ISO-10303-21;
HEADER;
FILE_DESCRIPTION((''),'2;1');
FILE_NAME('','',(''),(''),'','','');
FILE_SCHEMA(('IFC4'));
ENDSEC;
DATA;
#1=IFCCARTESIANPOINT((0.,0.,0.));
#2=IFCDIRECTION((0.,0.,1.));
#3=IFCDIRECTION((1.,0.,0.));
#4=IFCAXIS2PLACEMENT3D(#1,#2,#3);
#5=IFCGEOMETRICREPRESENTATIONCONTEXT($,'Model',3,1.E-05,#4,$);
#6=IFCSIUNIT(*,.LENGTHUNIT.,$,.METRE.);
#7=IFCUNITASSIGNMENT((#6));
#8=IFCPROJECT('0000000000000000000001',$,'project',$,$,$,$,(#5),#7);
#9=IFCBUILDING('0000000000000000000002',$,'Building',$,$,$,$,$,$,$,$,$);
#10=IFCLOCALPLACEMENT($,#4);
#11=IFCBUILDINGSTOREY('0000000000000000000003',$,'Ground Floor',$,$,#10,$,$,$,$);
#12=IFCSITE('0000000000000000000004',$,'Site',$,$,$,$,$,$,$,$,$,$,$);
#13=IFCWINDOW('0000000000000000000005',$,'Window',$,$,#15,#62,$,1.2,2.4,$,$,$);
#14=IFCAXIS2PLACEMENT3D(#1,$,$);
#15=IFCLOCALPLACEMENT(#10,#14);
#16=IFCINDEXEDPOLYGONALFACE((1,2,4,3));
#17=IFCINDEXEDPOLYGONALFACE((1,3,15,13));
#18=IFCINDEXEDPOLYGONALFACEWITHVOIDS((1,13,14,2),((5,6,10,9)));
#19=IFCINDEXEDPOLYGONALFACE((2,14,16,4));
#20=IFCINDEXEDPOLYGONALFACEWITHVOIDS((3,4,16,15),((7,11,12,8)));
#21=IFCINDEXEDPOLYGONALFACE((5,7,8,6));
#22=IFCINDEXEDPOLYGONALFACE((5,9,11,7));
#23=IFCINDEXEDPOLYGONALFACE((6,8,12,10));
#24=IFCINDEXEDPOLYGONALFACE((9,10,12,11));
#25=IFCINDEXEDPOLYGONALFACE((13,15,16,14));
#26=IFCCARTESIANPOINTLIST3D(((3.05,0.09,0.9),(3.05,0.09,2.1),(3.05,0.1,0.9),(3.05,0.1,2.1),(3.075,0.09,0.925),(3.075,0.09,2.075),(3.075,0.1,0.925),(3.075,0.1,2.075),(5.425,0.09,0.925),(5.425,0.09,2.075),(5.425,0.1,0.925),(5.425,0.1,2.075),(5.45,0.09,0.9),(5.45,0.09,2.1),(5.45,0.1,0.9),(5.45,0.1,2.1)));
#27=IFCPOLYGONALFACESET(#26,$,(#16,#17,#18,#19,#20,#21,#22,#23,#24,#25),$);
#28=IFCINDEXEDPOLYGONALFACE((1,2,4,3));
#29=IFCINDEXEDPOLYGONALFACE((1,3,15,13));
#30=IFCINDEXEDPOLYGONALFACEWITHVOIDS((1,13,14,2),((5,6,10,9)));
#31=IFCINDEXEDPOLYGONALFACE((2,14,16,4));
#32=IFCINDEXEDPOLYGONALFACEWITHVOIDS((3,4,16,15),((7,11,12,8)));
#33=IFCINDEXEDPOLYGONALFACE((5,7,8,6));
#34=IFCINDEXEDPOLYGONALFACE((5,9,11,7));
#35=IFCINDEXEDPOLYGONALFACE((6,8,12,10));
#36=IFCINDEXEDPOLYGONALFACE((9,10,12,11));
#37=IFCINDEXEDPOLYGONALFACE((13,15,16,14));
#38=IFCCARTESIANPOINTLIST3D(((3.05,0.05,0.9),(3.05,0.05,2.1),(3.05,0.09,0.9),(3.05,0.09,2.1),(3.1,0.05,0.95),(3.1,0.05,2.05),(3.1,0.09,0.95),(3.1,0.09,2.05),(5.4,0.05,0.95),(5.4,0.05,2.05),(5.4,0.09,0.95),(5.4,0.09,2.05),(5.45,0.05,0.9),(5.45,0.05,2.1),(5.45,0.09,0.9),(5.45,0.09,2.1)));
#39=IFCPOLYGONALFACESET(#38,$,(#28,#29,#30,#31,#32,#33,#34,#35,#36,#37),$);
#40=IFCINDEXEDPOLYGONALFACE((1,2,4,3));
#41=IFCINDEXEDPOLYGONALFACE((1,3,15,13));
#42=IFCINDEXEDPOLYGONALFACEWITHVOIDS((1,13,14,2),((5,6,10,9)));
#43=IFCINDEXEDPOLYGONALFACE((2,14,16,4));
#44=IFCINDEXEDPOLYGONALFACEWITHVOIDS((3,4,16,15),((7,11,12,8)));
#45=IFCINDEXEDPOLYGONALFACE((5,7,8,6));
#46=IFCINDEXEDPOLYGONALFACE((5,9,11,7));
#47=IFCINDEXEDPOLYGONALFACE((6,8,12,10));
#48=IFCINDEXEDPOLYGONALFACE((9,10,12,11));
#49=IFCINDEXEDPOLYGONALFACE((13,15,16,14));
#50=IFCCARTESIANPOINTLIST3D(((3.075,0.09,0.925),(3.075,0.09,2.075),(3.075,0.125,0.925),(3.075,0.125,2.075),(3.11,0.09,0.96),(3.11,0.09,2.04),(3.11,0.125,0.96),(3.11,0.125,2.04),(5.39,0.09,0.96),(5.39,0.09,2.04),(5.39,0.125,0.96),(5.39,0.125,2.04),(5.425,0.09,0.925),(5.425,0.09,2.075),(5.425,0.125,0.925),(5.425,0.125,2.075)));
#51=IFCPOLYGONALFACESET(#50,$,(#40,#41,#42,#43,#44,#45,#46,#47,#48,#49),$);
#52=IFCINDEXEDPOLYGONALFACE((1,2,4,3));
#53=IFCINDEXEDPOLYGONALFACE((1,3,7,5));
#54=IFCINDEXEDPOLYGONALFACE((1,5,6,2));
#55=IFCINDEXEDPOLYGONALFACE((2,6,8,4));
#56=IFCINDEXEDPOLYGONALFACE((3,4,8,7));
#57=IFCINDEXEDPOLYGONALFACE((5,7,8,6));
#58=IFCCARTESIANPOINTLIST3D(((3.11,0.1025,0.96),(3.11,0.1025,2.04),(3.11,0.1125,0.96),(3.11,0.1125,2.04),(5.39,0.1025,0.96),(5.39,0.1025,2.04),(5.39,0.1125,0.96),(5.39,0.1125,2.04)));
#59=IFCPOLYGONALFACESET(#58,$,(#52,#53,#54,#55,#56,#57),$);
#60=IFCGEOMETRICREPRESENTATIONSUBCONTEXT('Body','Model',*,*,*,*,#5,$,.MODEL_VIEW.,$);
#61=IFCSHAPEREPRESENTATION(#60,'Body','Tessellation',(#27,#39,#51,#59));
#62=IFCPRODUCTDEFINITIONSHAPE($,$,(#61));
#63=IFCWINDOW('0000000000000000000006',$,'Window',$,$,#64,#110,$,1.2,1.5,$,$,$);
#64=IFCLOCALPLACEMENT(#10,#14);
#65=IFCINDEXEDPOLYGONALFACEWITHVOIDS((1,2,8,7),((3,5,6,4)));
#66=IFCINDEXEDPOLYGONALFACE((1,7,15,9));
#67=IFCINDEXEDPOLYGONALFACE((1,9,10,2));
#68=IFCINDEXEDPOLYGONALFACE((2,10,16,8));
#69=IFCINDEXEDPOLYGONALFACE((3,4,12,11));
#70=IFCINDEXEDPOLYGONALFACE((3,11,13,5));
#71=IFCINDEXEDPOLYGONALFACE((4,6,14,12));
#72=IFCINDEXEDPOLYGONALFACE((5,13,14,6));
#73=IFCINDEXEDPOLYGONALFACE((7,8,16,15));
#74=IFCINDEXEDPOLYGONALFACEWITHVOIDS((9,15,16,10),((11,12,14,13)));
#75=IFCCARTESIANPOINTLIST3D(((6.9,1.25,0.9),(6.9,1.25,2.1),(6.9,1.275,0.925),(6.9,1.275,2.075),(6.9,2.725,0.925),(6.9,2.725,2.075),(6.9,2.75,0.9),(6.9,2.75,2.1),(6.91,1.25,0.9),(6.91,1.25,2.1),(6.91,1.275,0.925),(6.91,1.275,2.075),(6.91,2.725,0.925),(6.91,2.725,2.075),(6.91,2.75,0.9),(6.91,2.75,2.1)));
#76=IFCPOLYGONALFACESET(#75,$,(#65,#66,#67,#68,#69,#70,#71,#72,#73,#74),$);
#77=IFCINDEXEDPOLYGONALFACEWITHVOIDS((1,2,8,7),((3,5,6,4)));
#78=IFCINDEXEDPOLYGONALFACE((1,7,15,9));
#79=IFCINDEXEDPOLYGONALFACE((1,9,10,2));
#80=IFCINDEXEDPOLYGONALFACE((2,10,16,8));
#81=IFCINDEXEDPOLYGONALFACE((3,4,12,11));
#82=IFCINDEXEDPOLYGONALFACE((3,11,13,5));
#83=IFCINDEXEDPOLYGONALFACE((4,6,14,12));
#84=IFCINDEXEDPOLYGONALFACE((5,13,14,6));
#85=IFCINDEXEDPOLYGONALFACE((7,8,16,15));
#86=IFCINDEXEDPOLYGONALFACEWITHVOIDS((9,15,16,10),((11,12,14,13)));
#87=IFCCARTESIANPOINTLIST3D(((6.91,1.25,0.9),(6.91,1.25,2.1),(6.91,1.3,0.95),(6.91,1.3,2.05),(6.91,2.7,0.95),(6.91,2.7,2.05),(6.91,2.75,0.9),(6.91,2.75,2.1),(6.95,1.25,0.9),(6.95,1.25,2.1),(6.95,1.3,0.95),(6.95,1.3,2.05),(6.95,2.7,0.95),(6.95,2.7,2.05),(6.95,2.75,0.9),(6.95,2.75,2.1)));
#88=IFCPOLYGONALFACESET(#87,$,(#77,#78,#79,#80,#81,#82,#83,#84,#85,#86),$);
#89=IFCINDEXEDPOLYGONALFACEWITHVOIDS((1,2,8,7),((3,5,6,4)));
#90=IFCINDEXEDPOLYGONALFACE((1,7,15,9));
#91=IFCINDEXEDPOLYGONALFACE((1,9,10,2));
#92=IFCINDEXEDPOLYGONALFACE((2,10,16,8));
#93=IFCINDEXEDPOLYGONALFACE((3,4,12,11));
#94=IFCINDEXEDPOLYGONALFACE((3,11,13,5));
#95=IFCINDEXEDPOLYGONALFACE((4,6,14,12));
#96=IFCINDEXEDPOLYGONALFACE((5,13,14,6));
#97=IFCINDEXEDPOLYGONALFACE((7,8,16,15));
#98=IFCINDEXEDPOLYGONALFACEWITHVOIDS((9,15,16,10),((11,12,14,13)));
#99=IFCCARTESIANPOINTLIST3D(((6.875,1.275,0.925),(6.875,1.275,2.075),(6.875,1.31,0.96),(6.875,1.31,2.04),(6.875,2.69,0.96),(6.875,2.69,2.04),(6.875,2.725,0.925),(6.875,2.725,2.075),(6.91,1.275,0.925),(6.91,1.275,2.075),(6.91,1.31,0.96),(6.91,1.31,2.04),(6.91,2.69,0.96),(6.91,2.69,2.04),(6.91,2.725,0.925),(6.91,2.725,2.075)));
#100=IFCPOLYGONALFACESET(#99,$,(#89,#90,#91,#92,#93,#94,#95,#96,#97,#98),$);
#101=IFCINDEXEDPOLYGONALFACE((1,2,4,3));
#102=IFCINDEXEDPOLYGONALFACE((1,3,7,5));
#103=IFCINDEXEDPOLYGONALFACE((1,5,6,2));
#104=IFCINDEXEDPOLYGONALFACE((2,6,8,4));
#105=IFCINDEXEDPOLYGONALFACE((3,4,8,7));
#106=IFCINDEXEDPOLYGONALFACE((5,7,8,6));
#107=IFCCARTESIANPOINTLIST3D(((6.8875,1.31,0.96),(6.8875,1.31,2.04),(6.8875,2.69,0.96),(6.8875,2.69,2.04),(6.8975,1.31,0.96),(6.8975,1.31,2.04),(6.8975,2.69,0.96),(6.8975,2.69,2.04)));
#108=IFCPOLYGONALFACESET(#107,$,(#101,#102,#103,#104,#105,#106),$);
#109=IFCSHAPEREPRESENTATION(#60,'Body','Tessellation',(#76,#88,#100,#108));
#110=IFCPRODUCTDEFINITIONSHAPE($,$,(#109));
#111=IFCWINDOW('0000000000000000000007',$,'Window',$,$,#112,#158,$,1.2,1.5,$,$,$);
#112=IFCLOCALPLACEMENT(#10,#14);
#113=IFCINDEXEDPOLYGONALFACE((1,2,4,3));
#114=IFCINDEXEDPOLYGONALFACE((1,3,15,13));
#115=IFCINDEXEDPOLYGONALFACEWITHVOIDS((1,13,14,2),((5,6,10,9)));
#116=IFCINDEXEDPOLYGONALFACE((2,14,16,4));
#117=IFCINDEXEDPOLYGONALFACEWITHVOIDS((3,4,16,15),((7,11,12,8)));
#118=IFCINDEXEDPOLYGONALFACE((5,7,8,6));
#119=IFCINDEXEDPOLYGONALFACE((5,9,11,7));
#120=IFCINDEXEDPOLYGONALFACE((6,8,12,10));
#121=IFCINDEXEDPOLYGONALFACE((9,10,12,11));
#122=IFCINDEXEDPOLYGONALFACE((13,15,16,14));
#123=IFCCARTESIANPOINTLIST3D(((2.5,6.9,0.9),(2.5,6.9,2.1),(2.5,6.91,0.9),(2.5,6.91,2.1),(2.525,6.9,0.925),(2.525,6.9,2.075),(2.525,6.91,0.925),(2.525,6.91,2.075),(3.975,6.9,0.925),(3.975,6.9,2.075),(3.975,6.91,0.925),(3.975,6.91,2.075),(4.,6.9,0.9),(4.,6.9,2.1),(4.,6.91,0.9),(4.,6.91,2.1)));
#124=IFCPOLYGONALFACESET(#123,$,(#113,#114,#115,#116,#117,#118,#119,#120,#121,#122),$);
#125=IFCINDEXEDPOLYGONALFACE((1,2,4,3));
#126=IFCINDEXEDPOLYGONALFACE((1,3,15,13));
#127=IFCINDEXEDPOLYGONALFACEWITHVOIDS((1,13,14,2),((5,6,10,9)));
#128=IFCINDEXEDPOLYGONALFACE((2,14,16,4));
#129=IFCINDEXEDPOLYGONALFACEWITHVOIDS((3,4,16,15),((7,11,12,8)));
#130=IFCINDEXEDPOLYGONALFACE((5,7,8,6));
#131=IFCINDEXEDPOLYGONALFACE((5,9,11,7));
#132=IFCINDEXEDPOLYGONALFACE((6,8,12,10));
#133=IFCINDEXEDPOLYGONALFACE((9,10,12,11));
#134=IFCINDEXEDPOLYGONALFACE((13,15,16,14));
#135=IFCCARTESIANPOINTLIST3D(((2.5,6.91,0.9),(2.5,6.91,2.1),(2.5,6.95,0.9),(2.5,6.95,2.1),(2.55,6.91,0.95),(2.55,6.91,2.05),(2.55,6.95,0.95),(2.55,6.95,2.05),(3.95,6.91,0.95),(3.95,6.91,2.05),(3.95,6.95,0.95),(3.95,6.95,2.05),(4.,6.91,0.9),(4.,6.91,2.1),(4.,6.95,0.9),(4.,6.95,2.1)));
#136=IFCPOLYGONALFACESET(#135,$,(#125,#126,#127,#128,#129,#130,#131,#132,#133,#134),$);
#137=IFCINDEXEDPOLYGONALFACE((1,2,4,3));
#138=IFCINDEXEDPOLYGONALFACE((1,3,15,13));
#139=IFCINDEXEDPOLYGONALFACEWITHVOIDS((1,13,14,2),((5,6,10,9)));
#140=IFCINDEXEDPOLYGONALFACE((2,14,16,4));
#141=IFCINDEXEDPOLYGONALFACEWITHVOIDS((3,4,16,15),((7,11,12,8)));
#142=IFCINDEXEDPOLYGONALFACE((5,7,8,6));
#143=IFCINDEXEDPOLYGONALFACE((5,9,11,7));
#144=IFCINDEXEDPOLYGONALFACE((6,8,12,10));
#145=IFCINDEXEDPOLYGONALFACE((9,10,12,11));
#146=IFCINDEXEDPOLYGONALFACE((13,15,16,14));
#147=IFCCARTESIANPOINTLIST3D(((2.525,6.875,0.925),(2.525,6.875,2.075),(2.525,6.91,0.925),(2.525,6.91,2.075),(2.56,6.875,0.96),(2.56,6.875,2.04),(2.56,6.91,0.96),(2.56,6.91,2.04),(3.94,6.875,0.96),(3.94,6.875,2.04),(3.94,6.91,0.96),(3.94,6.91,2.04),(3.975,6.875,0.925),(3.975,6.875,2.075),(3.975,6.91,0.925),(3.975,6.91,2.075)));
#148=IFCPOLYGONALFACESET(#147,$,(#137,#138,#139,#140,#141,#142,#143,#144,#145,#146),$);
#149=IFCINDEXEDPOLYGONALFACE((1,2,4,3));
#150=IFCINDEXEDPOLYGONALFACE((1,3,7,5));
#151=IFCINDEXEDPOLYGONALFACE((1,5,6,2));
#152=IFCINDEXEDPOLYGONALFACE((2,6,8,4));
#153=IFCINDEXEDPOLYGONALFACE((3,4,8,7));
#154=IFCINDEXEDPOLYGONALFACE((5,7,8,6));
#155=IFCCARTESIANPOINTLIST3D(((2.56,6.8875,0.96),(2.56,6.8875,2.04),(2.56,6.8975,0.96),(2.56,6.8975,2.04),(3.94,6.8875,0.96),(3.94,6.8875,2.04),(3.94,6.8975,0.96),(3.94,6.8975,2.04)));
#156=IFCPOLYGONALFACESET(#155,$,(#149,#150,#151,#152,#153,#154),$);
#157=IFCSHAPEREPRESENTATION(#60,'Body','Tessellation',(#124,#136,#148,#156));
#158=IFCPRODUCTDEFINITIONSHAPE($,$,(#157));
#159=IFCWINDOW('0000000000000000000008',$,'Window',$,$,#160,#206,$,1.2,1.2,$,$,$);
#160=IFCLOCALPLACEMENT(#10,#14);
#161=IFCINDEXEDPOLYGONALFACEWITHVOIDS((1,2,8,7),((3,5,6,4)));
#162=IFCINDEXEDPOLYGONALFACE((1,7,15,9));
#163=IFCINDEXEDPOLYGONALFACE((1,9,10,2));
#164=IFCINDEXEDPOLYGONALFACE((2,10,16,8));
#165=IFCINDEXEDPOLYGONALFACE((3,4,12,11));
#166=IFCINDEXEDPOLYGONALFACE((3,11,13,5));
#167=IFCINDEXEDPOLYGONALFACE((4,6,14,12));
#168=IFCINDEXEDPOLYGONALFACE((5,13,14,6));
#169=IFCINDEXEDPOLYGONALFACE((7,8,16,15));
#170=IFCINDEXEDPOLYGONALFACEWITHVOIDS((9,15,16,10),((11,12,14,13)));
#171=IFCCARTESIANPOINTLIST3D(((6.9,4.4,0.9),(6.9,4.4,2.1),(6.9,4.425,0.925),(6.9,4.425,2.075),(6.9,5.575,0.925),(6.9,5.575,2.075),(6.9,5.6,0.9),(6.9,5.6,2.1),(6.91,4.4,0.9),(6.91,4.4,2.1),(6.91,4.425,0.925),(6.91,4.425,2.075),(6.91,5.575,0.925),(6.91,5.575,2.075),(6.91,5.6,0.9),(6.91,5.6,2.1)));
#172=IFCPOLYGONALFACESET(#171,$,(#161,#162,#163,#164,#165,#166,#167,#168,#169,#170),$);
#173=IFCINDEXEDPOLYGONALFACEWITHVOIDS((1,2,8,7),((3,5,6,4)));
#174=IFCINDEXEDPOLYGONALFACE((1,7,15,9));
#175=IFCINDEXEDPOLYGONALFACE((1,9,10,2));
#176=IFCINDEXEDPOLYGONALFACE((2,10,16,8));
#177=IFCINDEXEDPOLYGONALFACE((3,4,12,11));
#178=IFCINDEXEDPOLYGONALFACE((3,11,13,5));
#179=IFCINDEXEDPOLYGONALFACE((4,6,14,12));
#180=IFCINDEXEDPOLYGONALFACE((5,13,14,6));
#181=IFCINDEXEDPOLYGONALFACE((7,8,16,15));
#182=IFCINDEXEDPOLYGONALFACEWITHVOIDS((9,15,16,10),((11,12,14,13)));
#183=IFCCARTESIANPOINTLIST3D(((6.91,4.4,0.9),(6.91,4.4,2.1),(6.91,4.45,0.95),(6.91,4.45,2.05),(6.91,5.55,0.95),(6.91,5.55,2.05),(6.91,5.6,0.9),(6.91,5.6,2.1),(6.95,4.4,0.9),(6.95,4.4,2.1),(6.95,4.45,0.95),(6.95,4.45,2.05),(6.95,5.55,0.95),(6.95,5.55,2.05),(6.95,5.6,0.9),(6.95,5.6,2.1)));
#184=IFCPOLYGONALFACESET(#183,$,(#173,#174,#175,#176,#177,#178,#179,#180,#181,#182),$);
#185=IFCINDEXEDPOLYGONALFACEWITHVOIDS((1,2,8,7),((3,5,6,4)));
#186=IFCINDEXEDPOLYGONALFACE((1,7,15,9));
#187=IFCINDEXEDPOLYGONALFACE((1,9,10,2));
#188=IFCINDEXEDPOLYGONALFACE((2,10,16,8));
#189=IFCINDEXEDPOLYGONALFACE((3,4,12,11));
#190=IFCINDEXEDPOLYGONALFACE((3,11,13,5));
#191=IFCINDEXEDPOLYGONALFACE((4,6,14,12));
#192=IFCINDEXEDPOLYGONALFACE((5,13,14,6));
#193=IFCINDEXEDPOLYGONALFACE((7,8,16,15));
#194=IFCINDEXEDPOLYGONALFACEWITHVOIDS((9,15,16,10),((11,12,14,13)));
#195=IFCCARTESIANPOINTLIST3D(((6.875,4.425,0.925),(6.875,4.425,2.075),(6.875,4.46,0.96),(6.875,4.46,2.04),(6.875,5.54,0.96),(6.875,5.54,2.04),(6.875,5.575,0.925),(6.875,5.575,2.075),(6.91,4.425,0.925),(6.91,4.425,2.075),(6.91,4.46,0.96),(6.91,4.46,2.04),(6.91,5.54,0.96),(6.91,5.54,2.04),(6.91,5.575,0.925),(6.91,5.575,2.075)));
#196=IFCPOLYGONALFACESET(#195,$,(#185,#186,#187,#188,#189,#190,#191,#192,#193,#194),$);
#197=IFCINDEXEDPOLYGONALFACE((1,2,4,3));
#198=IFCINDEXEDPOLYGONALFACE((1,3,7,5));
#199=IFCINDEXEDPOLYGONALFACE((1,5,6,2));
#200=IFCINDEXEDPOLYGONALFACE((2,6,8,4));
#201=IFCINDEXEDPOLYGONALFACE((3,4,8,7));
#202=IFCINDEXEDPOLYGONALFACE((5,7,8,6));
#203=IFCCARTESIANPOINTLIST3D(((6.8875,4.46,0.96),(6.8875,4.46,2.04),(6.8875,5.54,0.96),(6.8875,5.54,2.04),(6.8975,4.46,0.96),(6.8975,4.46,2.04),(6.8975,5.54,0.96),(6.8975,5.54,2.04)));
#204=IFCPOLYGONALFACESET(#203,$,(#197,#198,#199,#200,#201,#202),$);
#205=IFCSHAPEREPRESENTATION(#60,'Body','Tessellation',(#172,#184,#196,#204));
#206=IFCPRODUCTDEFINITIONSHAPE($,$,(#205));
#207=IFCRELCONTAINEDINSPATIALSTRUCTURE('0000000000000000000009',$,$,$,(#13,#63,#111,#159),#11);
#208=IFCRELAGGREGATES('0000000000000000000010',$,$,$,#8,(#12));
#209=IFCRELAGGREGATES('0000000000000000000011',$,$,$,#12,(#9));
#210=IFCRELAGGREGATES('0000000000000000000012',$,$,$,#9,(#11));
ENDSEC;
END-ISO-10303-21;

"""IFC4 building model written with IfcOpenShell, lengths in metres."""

from ifc_helpers import new_model, si_unit, frame, origin_with_axes, place, context, subcontext, project, spatial, line, indexed_curve, outline, extrude, element, save


model = new_model("IFC4")

# Units and contexts
model_context = context("Model", 3, precision=1e-05, world=origin_with_axes())
body_context = subcontext(model_context, "Body", "Model", "MODEL_VIEW")
ifc_project = project(units=[si_unit("LENGTHUNIT", "METRE")], contexts=[model_context])

# Site, building, storey
site = spatial("IfcSite", under=ifc_project, Name="Site")
building = spatial("IfcBuilding", under=site, Name="Building")
storey_placement = place(None, origin_with_axes())
storey = spatial("IfcBuildingStorey", under=building, at=storey_placement, Name="Ground Floor")

# Windows
window_placement = place(storey_placement, frame((3.05, 0.0, 0.9), z_axis=(0.0, 0.0, 1.0), x_axis=(1.0, 0.0, 0.0)))
element("IfcWindow", 1, at=window_placement, inside=storey, Name="Window", OverallHeight=1.2, OverallWidth=2.4, context=body_context, shape_type="SweptSolid", body=[
    extrude(outline(indexed_curve([(0.0, 0.0), (2.4, 0.0), (2.4, 1.2), (0.0, 1.2)], segments=[line(1, 2, 3, 4, 1)]), holes=[indexed_curve([(0.025, 0.025), (2.375, 0.025), (2.375, 1.175), (0.025, 1.175)], segments=[line(1, 2, 3, 4, 1)])]), frame((0.0, 0.09, 0.0), z_axis=(0.0, -1.0, 0.0), x_axis=(1.0, 0.0, 0.0)), (0.0, 0.0, -1.0), 0.01),
    extrude(outline(indexed_curve([(0.0, 0.0), (2.4, 0.0), (2.4, 1.2), (0.0, 1.2)], segments=[line(1, 2, 3, 4, 1)]), holes=[indexed_curve([(0.05, 0.05), (2.35, 0.05), (2.35, 1.15), (0.05, 1.15)], segments=[line(1, 2, 3, 4, 1)])]), frame((0.0, 0.05, 0.0), z_axis=(0.0, -1.0, 0.0), x_axis=(1.0, 0.0, 0.0)), (0.0, 0.0, -1.0), 0.04),
    extrude(outline(indexed_curve([(0.0, 0.0), (2.35, 0.0), (2.35, 1.15), (0.0, 1.15)], segments=[line(1, 2, 3, 4, 1)]), holes=[indexed_curve([(0.035, 0.035), (2.315, 0.035), (2.315, 1.115), (0.035, 1.115)], segments=[line(1, 2, 3, 4, 1)])]), frame((0.025, 0.09, 0.025), z_axis=(0.0, -1.0, 0.0), x_axis=(1.0, 0.0, 0.0)), (0.0, 0.0, -1.0), 0.035),
    extrude(outline(indexed_curve([(0.035, 0.035), (2.315, 0.035), (2.315, 1.115), (0.035, 1.115)], segments=[line(1, 2, 3, 4, 1)])), frame((0.025, 0.1025, 0.025), z_axis=(0.0, -1.0, 0.0), x_axis=(1.0, 0.0, 0.0)), (0.0, 0.0, -1.0), 0.01),
])
for number, where, z_axis, x_axis, name in (
    (2, (7.0, 1.25, 0.9), (0.0, 0.0, 1.0), (0.0, 1.0, 0.0), "Window"),
    (3, (4.0, 7.0, 0.9), (0.0, 0.0, 1.0), (-1.0, 0.0, 0.0), "Window"),
):
    element("IfcWindow", number, at=place(storey_placement, frame(where, z_axis=z_axis, x_axis=x_axis)), inside=storey, Name=name, OverallHeight=1.2, OverallWidth=1.5, context=body_context, shape_type="SweptSolid", body=[
        extrude(outline(indexed_curve([(0.0, 0.0), (1.5, 0.0), (1.5, 1.2), (0.0, 1.2)], segments=[line(1, 2, 3, 4, 1)]), holes=[indexed_curve([(0.025, 0.025), (1.475, 0.025), (1.475, 1.175), (0.025, 1.175)], segments=[line(1, 2, 3, 4, 1)])]), frame((0.0, 0.09, 0.0), z_axis=(0.0, -1.0, 0.0), x_axis=(1.0, 0.0, 0.0)), (0.0, 0.0, -1.0), 0.01),
        extrude(outline(indexed_curve([(0.0, 0.0), (1.5, 0.0), (1.5, 1.2), (0.0, 1.2)], segments=[line(1, 2, 3, 4, 1)]), holes=[indexed_curve([(0.05, 0.05), (1.45, 0.05), (1.45, 1.15), (0.05, 1.15)], segments=[line(1, 2, 3, 4, 1)])]), frame((0.0, 0.05, 0.0), z_axis=(0.0, -1.0, 0.0), x_axis=(1.0, 0.0, 0.0)), (0.0, 0.0, -1.0), 0.04),
        extrude(outline(indexed_curve([(0.0, 0.0), (1.45, 0.0), (1.45, 1.15), (0.0, 1.15)], segments=[line(1, 2, 3, 4, 1)]), holes=[indexed_curve([(0.035, 0.035), (1.415, 0.035), (1.415, 1.115), (0.035, 1.115)], segments=[line(1, 2, 3, 4, 1)])]), frame((0.025, 0.09, 0.025), z_axis=(0.0, -1.0, 0.0), x_axis=(1.0, 0.0, 0.0)), (0.0, 0.0, -1.0), 0.035),
        extrude(outline(indexed_curve([(0.035, 0.035), (1.415, 0.035), (1.415, 1.115), (0.035, 1.115)], segments=[line(1, 2, 3, 4, 1)])), frame((0.025, 0.1025, 0.025), z_axis=(0.0, -1.0, 0.0), x_axis=(1.0, 0.0, 0.0)), (0.0, 0.0, -1.0), 0.01),
    ])
for number, where, z_axis, x_axis, name in (
    (4, (7.0, 4.4, 0.9), (0.0, 0.0, 1.0), (0.0, 1.0, 0.0), "Window"),
):
    element("IfcWindow", number, at=place(storey_placement, frame(where, z_axis=z_axis, x_axis=x_axis)), inside=storey, Name=name, OverallHeight=1.2, OverallWidth=1.2, context=body_context, shape_type="SweptSolid", body=[
        extrude(outline(indexed_curve([(0.0, 0.0), (1.2, 0.0), (1.2, 1.2), (0.0, 1.2)], segments=[line(1, 2, 3, 4, 1)]), holes=[indexed_curve([(0.025, 0.025), (1.175, 0.025), (1.175, 1.175), (0.025, 1.175)], segments=[line(1, 2, 3, 4, 1)])]), frame((0.0, 0.09, 0.0), z_axis=(0.0, -1.0, 0.0), x_axis=(1.0, 0.0, 0.0)), (0.0, 0.0, -1.0), 0.01),
        extrude(outline(indexed_curve([(0.0, 0.0), (1.2, 0.0), (1.2, 1.2), (0.0, 1.2)], segments=[line(1, 2, 3, 4, 1)]), holes=[indexed_curve([(0.05, 0.05), (1.15, 0.05), (1.15, 1.15), (0.05, 1.15)], segments=[line(1, 2, 3, 4, 1)])]), frame((0.0, 0.05, 0.0), z_axis=(0.0, -1.0, 0.0), x_axis=(1.0, 0.0, 0.0)), (0.0, 0.0, -1.0), 0.04),
        extrude(outline(indexed_curve([(0.0, 0.0), (1.15, 0.0), (1.15, 1.15), (0.0, 1.15)], segments=[line(1, 2, 3, 4, 1)]), holes=[indexed_curve([(0.035, 0.035), (1.115, 0.035), (1.115, 1.115), (0.035, 1.115)], segments=[line(1, 2, 3, 4, 1)])]), frame((0.025, 0.09, 0.025), z_axis=(0.0, -1.0, 0.0), x_axis=(1.0, 0.0, 0.0)), (0.0, 0.0, -1.0), 0.035),
        extrude(outline(indexed_curve([(0.035, 0.035), (1.115, 0.035), (1.115, 1.115), (0.035, 1.115)], segments=[line(1, 2, 3, 4, 1)])), frame((0.025, 0.1025, 0.025), z_axis=(0.0, -1.0, 0.0), x_axis=(1.0, 0.0, 0.0)), (0.0, 0.0, -1.0), 0.01),
    ])

save(model, "model.ifc")
